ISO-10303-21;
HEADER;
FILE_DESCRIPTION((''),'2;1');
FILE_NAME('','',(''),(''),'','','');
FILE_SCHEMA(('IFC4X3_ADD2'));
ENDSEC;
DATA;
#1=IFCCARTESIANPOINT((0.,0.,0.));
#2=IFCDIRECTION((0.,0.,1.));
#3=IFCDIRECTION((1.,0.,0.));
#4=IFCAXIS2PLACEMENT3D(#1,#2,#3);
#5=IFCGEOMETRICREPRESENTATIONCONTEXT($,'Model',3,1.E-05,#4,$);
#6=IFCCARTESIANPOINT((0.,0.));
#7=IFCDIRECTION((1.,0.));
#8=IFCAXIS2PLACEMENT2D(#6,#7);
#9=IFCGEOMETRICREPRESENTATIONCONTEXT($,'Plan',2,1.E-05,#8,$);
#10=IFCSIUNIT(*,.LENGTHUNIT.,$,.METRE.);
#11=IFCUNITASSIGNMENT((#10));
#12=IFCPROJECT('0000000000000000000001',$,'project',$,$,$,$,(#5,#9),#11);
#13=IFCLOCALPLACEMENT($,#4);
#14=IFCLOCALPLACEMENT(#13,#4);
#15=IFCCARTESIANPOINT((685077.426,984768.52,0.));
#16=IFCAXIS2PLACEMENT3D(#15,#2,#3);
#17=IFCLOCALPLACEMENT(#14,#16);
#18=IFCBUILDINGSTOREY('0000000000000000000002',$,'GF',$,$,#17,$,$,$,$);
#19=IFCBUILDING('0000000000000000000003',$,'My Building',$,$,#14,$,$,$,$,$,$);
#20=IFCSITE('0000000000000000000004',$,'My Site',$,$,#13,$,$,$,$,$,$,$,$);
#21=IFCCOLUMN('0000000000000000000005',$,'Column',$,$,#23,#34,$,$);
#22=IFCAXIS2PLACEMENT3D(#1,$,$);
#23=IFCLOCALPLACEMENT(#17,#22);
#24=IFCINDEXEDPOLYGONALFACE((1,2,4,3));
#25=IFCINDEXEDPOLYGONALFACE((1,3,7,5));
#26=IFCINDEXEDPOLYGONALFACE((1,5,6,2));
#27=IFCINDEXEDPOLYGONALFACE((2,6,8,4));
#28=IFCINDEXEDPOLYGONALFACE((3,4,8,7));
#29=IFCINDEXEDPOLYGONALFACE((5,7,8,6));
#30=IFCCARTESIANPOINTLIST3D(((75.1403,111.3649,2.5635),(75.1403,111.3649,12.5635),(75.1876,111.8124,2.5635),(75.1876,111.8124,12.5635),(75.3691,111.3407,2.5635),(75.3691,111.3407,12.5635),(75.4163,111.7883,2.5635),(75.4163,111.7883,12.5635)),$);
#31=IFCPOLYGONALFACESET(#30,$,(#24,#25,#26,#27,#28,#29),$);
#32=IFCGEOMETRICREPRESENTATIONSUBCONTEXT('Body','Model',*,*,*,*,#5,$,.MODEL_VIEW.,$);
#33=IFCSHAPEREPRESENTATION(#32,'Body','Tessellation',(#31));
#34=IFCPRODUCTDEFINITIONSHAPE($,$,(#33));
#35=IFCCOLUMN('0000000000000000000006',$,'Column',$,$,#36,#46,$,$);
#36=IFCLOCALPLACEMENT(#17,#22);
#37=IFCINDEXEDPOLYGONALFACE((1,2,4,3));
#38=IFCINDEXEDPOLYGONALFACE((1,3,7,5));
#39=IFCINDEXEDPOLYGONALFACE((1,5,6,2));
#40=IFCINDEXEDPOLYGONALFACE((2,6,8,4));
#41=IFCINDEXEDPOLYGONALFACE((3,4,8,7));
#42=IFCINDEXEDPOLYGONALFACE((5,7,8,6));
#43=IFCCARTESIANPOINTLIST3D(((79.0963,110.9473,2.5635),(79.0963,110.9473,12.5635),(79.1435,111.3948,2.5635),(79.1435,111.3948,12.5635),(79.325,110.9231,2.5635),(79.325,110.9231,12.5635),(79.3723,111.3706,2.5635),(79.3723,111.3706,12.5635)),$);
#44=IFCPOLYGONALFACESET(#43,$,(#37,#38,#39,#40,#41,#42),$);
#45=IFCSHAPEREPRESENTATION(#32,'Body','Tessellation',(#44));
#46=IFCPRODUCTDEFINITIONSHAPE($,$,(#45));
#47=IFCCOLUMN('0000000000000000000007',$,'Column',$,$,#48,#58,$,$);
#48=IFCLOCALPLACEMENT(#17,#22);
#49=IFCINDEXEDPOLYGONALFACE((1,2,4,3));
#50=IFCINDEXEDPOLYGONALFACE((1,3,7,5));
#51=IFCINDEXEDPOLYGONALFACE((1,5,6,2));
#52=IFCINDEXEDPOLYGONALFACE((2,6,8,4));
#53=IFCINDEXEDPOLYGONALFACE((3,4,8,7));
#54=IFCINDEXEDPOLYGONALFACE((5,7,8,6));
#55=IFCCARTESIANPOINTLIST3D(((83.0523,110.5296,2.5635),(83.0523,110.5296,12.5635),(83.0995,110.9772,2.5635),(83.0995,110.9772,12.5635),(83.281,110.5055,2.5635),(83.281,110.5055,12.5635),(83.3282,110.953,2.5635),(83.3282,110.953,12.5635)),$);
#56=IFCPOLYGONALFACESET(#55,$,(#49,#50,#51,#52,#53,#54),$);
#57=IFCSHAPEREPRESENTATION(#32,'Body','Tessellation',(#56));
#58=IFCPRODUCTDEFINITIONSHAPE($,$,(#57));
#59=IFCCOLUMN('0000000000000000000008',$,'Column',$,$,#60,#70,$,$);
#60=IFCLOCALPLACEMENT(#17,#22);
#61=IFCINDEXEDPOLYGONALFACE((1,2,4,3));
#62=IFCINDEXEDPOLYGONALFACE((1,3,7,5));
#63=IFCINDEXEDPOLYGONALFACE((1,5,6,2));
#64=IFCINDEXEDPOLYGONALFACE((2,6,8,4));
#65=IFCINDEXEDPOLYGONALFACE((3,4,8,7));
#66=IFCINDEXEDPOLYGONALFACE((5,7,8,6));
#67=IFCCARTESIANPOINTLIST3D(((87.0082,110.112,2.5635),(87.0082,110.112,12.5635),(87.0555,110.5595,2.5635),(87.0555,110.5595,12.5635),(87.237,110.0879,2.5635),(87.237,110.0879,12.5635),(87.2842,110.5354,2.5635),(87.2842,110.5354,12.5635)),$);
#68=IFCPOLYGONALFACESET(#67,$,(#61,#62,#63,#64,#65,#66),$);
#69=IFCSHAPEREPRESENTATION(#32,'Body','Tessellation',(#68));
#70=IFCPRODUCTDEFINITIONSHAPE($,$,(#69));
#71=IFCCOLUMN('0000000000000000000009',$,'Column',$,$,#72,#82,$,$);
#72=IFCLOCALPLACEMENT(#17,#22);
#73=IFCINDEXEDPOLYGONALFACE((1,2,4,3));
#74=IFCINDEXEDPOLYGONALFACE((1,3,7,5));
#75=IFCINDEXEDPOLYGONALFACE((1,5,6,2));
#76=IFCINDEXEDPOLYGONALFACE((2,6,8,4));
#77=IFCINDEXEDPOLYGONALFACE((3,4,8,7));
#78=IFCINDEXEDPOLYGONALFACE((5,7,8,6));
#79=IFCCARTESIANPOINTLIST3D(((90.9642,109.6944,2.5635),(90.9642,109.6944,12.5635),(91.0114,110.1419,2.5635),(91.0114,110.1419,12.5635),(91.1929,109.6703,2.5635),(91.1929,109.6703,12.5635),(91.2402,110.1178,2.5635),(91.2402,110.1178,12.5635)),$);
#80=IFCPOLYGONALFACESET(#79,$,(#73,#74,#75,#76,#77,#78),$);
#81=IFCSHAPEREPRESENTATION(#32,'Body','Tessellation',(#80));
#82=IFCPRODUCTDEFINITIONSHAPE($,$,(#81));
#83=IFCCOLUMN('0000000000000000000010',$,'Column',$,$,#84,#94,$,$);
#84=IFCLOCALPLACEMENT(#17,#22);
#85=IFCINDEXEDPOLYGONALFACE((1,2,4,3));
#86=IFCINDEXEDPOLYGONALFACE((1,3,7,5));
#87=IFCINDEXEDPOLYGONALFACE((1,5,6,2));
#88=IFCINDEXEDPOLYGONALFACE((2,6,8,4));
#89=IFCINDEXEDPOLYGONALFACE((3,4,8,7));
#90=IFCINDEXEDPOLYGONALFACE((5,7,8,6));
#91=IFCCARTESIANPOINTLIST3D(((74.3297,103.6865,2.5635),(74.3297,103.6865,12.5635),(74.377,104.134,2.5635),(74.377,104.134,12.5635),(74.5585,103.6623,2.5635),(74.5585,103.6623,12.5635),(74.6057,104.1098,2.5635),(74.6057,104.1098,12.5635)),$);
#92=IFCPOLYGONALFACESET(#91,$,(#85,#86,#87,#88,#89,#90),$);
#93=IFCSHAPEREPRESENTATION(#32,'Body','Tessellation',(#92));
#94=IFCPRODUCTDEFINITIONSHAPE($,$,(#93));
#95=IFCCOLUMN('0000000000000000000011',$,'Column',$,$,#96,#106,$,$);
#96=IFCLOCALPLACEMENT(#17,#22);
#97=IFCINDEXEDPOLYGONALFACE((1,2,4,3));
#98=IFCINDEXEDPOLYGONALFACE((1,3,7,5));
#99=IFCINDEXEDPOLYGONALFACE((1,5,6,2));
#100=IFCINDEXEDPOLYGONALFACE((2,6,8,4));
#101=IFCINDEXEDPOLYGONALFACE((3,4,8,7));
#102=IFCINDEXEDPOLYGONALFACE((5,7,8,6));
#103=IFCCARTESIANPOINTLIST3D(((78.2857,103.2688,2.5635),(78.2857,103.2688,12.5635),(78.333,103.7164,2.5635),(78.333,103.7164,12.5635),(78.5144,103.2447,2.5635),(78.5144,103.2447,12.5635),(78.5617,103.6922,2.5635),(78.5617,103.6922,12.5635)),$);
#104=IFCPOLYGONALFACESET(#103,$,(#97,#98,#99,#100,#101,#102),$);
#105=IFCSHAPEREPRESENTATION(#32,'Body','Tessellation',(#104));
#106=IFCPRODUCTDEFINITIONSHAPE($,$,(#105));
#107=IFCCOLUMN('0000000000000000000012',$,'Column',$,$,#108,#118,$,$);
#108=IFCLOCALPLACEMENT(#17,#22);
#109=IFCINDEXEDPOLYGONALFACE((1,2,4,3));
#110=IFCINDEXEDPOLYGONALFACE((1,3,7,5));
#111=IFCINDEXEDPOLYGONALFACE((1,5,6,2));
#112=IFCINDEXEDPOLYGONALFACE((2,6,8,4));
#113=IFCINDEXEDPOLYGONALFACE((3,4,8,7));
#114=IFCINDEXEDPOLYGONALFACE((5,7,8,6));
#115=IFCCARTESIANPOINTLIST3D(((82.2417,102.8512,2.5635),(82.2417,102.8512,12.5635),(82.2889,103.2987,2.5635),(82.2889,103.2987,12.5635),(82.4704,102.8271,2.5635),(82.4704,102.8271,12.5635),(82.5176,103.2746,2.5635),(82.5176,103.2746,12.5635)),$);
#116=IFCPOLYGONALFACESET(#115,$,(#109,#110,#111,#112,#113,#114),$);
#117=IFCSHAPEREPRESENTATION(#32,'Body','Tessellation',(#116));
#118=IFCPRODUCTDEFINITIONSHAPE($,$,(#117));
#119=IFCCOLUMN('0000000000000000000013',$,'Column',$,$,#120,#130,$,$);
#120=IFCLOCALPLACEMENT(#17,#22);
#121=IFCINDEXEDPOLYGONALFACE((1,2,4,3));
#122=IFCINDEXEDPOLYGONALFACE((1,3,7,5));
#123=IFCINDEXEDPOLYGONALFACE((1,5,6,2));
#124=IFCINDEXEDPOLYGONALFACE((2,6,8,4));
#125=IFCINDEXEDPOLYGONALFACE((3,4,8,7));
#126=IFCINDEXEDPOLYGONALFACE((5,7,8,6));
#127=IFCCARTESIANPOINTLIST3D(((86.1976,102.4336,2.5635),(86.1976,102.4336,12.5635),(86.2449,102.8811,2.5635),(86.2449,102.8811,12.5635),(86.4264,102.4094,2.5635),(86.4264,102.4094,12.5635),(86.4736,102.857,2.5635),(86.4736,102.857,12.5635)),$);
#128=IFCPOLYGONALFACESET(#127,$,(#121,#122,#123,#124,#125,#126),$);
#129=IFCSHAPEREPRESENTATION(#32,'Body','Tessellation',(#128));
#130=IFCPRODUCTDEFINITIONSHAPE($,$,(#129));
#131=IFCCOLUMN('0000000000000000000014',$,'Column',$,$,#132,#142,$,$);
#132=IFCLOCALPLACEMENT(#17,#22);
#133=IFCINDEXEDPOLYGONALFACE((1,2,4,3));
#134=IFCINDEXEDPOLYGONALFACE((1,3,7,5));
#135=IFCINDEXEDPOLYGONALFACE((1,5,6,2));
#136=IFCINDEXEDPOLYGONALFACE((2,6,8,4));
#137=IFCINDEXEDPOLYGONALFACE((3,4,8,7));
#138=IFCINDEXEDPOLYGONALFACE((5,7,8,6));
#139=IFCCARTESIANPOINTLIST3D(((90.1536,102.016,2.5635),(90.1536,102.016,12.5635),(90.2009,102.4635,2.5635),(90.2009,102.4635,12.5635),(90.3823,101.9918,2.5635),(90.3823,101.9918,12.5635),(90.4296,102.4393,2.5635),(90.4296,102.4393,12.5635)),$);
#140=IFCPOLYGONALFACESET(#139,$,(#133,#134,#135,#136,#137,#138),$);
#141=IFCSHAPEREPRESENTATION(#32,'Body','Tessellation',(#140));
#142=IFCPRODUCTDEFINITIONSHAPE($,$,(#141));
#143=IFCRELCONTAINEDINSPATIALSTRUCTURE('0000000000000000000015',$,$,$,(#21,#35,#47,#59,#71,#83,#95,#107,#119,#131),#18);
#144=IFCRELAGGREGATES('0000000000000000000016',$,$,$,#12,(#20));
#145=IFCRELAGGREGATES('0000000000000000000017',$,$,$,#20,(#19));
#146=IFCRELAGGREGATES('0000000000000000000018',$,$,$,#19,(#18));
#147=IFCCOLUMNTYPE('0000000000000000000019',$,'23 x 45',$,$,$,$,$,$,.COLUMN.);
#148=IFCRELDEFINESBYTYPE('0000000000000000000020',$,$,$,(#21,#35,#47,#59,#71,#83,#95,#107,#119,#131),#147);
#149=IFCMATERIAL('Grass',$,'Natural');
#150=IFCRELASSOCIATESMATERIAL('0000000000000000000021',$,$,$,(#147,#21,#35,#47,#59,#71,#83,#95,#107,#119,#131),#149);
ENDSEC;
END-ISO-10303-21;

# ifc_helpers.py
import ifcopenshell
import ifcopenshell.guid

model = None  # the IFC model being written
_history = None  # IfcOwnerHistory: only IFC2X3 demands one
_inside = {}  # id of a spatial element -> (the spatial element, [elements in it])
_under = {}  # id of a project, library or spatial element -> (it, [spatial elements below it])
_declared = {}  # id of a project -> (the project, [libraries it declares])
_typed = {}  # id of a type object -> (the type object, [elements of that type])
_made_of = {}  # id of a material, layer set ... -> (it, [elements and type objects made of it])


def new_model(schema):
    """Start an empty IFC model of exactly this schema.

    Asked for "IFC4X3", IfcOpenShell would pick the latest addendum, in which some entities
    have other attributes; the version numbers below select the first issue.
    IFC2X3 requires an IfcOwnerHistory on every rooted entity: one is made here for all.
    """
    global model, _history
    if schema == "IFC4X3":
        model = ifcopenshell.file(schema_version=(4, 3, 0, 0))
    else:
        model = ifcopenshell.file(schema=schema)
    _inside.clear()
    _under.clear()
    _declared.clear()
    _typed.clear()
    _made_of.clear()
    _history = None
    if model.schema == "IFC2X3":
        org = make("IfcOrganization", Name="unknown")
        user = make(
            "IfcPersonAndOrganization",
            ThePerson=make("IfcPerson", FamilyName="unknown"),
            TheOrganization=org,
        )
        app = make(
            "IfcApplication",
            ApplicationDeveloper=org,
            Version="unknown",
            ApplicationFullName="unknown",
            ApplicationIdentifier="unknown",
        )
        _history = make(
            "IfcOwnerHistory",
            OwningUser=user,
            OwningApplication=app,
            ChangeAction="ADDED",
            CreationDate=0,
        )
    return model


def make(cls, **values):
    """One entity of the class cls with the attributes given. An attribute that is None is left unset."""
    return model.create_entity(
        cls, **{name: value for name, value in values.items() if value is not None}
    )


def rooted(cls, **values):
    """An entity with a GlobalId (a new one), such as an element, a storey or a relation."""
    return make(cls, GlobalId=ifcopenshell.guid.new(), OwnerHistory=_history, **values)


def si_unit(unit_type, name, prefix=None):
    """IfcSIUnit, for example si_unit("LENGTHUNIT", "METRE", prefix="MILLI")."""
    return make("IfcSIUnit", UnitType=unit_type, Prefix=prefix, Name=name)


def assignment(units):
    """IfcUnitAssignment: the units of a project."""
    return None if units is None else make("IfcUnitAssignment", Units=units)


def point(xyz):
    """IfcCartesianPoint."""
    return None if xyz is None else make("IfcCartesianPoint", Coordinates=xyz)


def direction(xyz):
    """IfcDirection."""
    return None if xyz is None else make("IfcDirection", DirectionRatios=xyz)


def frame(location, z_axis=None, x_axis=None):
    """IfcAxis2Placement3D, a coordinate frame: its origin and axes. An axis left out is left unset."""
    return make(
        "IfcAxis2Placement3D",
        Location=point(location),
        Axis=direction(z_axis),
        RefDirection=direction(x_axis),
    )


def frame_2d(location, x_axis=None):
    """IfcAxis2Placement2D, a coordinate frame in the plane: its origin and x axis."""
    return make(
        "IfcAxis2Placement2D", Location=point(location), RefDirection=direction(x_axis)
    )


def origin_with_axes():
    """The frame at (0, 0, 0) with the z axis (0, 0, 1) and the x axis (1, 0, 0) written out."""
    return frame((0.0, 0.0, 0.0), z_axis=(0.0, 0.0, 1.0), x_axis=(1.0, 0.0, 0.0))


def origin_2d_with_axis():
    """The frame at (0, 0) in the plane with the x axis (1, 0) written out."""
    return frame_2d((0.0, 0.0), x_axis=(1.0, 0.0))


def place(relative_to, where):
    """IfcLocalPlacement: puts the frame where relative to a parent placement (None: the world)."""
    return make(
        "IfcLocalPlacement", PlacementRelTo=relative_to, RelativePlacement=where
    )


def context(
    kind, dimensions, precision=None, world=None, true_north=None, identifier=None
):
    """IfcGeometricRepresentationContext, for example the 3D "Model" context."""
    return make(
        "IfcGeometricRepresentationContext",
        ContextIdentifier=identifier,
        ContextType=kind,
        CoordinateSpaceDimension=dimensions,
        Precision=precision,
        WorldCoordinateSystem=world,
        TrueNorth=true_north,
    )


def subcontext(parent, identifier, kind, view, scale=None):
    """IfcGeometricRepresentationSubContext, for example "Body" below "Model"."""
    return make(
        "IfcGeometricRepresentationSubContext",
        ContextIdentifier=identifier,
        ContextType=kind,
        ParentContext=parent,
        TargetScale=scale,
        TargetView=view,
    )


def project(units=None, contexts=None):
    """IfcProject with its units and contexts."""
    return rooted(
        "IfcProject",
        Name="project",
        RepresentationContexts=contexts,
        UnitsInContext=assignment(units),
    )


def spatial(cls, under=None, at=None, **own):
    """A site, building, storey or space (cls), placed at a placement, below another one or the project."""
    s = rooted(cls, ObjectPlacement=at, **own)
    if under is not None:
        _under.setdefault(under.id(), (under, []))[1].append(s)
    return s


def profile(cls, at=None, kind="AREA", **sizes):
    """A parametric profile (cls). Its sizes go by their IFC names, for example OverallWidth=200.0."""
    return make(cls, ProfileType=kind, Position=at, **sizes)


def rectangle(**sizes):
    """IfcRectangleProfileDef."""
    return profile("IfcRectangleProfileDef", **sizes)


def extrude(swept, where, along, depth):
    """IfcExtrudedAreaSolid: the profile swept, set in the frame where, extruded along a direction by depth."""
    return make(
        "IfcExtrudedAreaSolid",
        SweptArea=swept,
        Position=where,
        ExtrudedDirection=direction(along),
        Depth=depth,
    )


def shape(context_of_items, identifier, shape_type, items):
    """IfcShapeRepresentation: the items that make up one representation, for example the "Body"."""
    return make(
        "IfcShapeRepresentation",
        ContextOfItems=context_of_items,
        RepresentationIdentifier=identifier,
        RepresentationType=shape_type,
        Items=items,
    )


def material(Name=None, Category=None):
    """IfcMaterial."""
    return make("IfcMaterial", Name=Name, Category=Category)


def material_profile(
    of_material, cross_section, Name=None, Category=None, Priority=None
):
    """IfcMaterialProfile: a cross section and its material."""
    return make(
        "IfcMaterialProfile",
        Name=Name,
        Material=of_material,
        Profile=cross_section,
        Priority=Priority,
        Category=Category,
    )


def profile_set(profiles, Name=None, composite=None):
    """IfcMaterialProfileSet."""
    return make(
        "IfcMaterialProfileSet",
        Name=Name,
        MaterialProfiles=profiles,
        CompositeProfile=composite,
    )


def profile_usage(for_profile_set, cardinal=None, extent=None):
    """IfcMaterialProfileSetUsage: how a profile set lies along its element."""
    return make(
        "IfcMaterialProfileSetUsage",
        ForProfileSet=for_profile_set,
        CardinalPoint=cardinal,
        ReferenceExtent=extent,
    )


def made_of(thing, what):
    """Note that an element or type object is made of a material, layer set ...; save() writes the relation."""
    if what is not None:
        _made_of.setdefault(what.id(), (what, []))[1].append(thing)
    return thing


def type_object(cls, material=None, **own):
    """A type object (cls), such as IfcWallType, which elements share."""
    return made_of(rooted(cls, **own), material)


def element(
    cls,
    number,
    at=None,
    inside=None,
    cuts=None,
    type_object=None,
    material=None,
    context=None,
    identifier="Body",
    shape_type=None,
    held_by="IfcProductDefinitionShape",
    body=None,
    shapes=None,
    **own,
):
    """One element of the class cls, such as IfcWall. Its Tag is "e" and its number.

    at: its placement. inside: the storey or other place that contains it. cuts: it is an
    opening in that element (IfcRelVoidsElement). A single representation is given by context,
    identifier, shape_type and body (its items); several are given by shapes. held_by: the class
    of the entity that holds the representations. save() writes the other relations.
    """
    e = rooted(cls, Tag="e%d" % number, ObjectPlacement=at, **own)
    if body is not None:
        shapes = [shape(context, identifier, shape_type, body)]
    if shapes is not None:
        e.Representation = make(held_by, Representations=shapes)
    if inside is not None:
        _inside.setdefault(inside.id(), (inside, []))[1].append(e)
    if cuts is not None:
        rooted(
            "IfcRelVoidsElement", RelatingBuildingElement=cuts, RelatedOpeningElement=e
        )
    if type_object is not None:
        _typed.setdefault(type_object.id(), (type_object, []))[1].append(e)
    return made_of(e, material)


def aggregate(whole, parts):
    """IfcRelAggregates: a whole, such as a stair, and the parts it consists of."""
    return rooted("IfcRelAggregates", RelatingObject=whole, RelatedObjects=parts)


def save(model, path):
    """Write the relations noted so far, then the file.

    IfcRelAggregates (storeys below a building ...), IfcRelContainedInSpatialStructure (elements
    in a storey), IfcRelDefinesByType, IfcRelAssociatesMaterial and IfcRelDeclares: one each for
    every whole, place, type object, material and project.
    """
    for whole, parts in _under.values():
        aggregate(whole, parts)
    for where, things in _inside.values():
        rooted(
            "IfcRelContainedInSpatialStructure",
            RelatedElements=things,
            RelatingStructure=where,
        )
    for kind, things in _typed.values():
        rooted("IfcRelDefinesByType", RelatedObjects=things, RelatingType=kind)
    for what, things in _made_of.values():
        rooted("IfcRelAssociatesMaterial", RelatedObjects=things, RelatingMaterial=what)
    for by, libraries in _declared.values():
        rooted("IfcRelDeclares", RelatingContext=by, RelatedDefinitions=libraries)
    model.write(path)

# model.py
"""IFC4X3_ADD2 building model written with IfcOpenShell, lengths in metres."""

from ifc_helpers import new_model, si_unit, frame, origin_with_axes, origin_2d_with_axis, place, context, subcontext, project, spatial, rectangle, extrude, material, material_profile, profile_set, profile_usage, type_object, element, save


model = new_model("IFC4X3_ADD2")

# Units and contexts
model_context = context("Model", 3, precision=1e-05, world=origin_with_axes())
plan_context = context("Plan", 2, precision=1e-05, world=origin_2d_with_axis())
body_context = subcontext(model_context, "Body", "Model", "MODEL_VIEW")
ifc_project = project(units=[si_unit("LENGTHUNIT", "METRE")], contexts=[model_context, plan_context])

# Site, building, storey
site_placement = place(None, origin_with_axes())
site = spatial("IfcSite", under=ifc_project, at=site_placement, Name="My Site")
building_placement = place(site_placement, origin_with_axes())
building = spatial("IfcBuilding", under=site, at=building_placement, Name="My Building")
storey_placement = place(building_placement, frame((685077.426, 984768.52, 0.0), z_axis=(0.0, 0.0, 1.0), x_axis=(1.0, 0.0, 0.0)))
storey = spatial("IfcBuildingStorey", under=building, at=storey_placement, Name="GF")

# Columns
ifc_material = material(Name="Grass", Category="Natural")
ifc_material_profile = material_profile(ifc_material, rectangle(XDim=0.45, YDim=0.23))
ifc_profile_set = profile_set([ifc_material_profile])
ifc_profile_usage_1 = profile_usage(ifc_profile_set, cardinal=5)
column_type = type_object("IfcColumnType", Name="23 x 45", PredefinedType="COLUMN", material=ifc_profile_set)
column_1_placement = place(storey_placement, frame((75.2783, 111.5766, 2.5635), z_axis=(0.0, 0.0, 1.0), x_axis=(-0.104984, -0.994474, 0.0)))
element("IfcColumn", 1, at=column_1_placement, inside=storey, type_object=column_type, material=ifc_profile_usage_1, Name="Column", context=body_context, shape_type="SweptSolid", body=[
    extrude(rectangle(XDim=0.45, YDim=0.23), origin_with_axes(), (0.0, 0.0, 1.0), 10.0),
])
ifc_profile_usage_2 = profile_usage(ifc_profile_set, cardinal=5)
column_2_placement = place(storey_placement, frame((79.2343, 111.159, 2.5635), z_axis=(0.0, 0.0, 1.0), x_axis=(-0.104984, -0.994474, 0.0)))
element("IfcColumn", 2, at=column_2_placement, inside=storey, type_object=column_type, material=ifc_profile_usage_2, Name="Column", context=body_context, shape_type="SweptSolid", body=[
    extrude(rectangle(XDim=0.45, YDim=0.23), origin_with_axes(), (0.0, 0.0, 1.0), 10.0),
])
ifc_profile_usage_3 = profile_usage(ifc_profile_set, cardinal=5)
column_3_placement = place(storey_placement, frame((83.1903, 110.7413, 2.5635), z_axis=(0.0, 0.0, 1.0), x_axis=(-0.104984, -0.994474, 0.0)))
element("IfcColumn", 3, at=column_3_placement, inside=storey, type_object=column_type, material=ifc_profile_usage_3, Name="Column", context=body_context, shape_type="SweptSolid", body=[
    extrude(rectangle(XDim=0.45, YDim=0.23), origin_with_axes(), (0.0, 0.0, 1.0), 10.0),
])
ifc_profile_usage_4 = profile_usage(ifc_profile_set, cardinal=5)
column_4_placement = place(storey_placement, frame((87.1462, 110.3237, 2.5635), z_axis=(0.0, 0.0, 1.0), x_axis=(-0.104984, -0.994474, 0.0)))
element("IfcColumn", 4, at=column_4_placement, inside=storey, type_object=column_type, material=ifc_profile_usage_4, Name="Column", context=body_context, shape_type="SweptSolid", body=[
    extrude(rectangle(XDim=0.45, YDim=0.23), origin_with_axes(), (0.0, 0.0, 1.0), 10.0),
])
ifc_profile_usage_5 = profile_usage(ifc_profile_set, cardinal=5)
column_5_placement = place(storey_placement, frame((91.1022, 109.9061, 2.5635), z_axis=(0.0, 0.0, 1.0), x_axis=(-0.104984, -0.994474, 0.0)))
element("IfcColumn", 5, at=column_5_placement, inside=storey, type_object=column_type, material=ifc_profile_usage_5, Name="Column", context=body_context, shape_type="SweptSolid", body=[
    extrude(rectangle(XDim=0.45, YDim=0.23), origin_with_axes(), (0.0, 0.0, 1.0), 10.0),
])
ifc_profile_usage_6 = profile_usage(ifc_profile_set, cardinal=5)
column_6_placement = place(storey_placement, frame((74.4677, 103.8981, 2.5635), z_axis=(0.0, 0.0, 1.0), x_axis=(-0.104984, -0.994474, 0.0)))
element("IfcColumn", 6, at=column_6_placement, inside=storey, type_object=column_type, material=ifc_profile_usage_6, Name="Column", context=body_context, shape_type="SweptSolid", body=[
    extrude(rectangle(XDim=0.45, YDim=0.23), origin_with_axes(), (0.0, 0.0, 1.0), 10.0),
])
ifc_profile_usage_7 = profile_usage(ifc_profile_set, cardinal=5)
column_7_placement = place(storey_placement, frame((78.4237, 103.4805, 2.5635), z_axis=(0.0, 0.0, 1.0), x_axis=(-0.104984, -0.994474, 0.0)))
element("IfcColumn", 7, at=column_7_placement, inside=storey, type_object=column_type, material=ifc_profile_usage_7, Name="Column", context=body_context, shape_type="SweptSolid", body=[
    extrude(rectangle(XDim=0.45, YDim=0.23), origin_with_axes(), (0.0, 0.0, 1.0), 10.0),
])
ifc_profile_usage_8 = profile_usage(ifc_profile_set, cardinal=5)
column_8_placement = place(storey_placement, frame((82.3797, 103.0629, 2.5635), z_axis=(0.0, 0.0, 1.0), x_axis=(-0.104984, -0.994474, 0.0)))
element("IfcColumn", 8, at=column_8_placement, inside=storey, type_object=column_type, material=ifc_profile_usage_8, Name="Column", context=body_context, shape_type="SweptSolid", body=[
    extrude(rectangle(XDim=0.45, YDim=0.23), origin_with_axes(), (0.0, 0.0, 1.0), 10.0),
])
ifc_profile_usage_9 = profile_usage(ifc_profile_set, cardinal=5)
column_9_placement = place(storey_placement, frame((86.3356, 102.6453, 2.5635), z_axis=(0.0, 0.0, 1.0), x_axis=(-0.104984, -0.994474, 0.0)))
element("IfcColumn", 9, at=column_9_placement, inside=storey, type_object=column_type, material=ifc_profile_usage_9, Name="Column", context=body_context, shape_type="SweptSolid", body=[
    extrude(rectangle(XDim=0.45, YDim=0.23), origin_with_axes(), (0.0, 0.0, 1.0), 10.0),
])
ifc_profile_usage_10 = profile_usage(ifc_profile_set, cardinal=5)
column_10_placement = place(storey_placement, frame((90.2916, 102.2277, 2.5635), z_axis=(0.0, 0.0, 1.0), x_axis=(-0.104984, -0.994474, 0.0)))
element("IfcColumn", 10, at=column_10_placement, inside=storey, type_object=column_type, material=ifc_profile_usage_10, Name="Column", context=body_context, shape_type="SweptSolid", body=[
    extrude(rectangle(XDim=0.45, YDim=0.23), origin_with_axes(), (0.0, 0.0, 1.0), 10.0),
])

save(model, "model.ifc")
